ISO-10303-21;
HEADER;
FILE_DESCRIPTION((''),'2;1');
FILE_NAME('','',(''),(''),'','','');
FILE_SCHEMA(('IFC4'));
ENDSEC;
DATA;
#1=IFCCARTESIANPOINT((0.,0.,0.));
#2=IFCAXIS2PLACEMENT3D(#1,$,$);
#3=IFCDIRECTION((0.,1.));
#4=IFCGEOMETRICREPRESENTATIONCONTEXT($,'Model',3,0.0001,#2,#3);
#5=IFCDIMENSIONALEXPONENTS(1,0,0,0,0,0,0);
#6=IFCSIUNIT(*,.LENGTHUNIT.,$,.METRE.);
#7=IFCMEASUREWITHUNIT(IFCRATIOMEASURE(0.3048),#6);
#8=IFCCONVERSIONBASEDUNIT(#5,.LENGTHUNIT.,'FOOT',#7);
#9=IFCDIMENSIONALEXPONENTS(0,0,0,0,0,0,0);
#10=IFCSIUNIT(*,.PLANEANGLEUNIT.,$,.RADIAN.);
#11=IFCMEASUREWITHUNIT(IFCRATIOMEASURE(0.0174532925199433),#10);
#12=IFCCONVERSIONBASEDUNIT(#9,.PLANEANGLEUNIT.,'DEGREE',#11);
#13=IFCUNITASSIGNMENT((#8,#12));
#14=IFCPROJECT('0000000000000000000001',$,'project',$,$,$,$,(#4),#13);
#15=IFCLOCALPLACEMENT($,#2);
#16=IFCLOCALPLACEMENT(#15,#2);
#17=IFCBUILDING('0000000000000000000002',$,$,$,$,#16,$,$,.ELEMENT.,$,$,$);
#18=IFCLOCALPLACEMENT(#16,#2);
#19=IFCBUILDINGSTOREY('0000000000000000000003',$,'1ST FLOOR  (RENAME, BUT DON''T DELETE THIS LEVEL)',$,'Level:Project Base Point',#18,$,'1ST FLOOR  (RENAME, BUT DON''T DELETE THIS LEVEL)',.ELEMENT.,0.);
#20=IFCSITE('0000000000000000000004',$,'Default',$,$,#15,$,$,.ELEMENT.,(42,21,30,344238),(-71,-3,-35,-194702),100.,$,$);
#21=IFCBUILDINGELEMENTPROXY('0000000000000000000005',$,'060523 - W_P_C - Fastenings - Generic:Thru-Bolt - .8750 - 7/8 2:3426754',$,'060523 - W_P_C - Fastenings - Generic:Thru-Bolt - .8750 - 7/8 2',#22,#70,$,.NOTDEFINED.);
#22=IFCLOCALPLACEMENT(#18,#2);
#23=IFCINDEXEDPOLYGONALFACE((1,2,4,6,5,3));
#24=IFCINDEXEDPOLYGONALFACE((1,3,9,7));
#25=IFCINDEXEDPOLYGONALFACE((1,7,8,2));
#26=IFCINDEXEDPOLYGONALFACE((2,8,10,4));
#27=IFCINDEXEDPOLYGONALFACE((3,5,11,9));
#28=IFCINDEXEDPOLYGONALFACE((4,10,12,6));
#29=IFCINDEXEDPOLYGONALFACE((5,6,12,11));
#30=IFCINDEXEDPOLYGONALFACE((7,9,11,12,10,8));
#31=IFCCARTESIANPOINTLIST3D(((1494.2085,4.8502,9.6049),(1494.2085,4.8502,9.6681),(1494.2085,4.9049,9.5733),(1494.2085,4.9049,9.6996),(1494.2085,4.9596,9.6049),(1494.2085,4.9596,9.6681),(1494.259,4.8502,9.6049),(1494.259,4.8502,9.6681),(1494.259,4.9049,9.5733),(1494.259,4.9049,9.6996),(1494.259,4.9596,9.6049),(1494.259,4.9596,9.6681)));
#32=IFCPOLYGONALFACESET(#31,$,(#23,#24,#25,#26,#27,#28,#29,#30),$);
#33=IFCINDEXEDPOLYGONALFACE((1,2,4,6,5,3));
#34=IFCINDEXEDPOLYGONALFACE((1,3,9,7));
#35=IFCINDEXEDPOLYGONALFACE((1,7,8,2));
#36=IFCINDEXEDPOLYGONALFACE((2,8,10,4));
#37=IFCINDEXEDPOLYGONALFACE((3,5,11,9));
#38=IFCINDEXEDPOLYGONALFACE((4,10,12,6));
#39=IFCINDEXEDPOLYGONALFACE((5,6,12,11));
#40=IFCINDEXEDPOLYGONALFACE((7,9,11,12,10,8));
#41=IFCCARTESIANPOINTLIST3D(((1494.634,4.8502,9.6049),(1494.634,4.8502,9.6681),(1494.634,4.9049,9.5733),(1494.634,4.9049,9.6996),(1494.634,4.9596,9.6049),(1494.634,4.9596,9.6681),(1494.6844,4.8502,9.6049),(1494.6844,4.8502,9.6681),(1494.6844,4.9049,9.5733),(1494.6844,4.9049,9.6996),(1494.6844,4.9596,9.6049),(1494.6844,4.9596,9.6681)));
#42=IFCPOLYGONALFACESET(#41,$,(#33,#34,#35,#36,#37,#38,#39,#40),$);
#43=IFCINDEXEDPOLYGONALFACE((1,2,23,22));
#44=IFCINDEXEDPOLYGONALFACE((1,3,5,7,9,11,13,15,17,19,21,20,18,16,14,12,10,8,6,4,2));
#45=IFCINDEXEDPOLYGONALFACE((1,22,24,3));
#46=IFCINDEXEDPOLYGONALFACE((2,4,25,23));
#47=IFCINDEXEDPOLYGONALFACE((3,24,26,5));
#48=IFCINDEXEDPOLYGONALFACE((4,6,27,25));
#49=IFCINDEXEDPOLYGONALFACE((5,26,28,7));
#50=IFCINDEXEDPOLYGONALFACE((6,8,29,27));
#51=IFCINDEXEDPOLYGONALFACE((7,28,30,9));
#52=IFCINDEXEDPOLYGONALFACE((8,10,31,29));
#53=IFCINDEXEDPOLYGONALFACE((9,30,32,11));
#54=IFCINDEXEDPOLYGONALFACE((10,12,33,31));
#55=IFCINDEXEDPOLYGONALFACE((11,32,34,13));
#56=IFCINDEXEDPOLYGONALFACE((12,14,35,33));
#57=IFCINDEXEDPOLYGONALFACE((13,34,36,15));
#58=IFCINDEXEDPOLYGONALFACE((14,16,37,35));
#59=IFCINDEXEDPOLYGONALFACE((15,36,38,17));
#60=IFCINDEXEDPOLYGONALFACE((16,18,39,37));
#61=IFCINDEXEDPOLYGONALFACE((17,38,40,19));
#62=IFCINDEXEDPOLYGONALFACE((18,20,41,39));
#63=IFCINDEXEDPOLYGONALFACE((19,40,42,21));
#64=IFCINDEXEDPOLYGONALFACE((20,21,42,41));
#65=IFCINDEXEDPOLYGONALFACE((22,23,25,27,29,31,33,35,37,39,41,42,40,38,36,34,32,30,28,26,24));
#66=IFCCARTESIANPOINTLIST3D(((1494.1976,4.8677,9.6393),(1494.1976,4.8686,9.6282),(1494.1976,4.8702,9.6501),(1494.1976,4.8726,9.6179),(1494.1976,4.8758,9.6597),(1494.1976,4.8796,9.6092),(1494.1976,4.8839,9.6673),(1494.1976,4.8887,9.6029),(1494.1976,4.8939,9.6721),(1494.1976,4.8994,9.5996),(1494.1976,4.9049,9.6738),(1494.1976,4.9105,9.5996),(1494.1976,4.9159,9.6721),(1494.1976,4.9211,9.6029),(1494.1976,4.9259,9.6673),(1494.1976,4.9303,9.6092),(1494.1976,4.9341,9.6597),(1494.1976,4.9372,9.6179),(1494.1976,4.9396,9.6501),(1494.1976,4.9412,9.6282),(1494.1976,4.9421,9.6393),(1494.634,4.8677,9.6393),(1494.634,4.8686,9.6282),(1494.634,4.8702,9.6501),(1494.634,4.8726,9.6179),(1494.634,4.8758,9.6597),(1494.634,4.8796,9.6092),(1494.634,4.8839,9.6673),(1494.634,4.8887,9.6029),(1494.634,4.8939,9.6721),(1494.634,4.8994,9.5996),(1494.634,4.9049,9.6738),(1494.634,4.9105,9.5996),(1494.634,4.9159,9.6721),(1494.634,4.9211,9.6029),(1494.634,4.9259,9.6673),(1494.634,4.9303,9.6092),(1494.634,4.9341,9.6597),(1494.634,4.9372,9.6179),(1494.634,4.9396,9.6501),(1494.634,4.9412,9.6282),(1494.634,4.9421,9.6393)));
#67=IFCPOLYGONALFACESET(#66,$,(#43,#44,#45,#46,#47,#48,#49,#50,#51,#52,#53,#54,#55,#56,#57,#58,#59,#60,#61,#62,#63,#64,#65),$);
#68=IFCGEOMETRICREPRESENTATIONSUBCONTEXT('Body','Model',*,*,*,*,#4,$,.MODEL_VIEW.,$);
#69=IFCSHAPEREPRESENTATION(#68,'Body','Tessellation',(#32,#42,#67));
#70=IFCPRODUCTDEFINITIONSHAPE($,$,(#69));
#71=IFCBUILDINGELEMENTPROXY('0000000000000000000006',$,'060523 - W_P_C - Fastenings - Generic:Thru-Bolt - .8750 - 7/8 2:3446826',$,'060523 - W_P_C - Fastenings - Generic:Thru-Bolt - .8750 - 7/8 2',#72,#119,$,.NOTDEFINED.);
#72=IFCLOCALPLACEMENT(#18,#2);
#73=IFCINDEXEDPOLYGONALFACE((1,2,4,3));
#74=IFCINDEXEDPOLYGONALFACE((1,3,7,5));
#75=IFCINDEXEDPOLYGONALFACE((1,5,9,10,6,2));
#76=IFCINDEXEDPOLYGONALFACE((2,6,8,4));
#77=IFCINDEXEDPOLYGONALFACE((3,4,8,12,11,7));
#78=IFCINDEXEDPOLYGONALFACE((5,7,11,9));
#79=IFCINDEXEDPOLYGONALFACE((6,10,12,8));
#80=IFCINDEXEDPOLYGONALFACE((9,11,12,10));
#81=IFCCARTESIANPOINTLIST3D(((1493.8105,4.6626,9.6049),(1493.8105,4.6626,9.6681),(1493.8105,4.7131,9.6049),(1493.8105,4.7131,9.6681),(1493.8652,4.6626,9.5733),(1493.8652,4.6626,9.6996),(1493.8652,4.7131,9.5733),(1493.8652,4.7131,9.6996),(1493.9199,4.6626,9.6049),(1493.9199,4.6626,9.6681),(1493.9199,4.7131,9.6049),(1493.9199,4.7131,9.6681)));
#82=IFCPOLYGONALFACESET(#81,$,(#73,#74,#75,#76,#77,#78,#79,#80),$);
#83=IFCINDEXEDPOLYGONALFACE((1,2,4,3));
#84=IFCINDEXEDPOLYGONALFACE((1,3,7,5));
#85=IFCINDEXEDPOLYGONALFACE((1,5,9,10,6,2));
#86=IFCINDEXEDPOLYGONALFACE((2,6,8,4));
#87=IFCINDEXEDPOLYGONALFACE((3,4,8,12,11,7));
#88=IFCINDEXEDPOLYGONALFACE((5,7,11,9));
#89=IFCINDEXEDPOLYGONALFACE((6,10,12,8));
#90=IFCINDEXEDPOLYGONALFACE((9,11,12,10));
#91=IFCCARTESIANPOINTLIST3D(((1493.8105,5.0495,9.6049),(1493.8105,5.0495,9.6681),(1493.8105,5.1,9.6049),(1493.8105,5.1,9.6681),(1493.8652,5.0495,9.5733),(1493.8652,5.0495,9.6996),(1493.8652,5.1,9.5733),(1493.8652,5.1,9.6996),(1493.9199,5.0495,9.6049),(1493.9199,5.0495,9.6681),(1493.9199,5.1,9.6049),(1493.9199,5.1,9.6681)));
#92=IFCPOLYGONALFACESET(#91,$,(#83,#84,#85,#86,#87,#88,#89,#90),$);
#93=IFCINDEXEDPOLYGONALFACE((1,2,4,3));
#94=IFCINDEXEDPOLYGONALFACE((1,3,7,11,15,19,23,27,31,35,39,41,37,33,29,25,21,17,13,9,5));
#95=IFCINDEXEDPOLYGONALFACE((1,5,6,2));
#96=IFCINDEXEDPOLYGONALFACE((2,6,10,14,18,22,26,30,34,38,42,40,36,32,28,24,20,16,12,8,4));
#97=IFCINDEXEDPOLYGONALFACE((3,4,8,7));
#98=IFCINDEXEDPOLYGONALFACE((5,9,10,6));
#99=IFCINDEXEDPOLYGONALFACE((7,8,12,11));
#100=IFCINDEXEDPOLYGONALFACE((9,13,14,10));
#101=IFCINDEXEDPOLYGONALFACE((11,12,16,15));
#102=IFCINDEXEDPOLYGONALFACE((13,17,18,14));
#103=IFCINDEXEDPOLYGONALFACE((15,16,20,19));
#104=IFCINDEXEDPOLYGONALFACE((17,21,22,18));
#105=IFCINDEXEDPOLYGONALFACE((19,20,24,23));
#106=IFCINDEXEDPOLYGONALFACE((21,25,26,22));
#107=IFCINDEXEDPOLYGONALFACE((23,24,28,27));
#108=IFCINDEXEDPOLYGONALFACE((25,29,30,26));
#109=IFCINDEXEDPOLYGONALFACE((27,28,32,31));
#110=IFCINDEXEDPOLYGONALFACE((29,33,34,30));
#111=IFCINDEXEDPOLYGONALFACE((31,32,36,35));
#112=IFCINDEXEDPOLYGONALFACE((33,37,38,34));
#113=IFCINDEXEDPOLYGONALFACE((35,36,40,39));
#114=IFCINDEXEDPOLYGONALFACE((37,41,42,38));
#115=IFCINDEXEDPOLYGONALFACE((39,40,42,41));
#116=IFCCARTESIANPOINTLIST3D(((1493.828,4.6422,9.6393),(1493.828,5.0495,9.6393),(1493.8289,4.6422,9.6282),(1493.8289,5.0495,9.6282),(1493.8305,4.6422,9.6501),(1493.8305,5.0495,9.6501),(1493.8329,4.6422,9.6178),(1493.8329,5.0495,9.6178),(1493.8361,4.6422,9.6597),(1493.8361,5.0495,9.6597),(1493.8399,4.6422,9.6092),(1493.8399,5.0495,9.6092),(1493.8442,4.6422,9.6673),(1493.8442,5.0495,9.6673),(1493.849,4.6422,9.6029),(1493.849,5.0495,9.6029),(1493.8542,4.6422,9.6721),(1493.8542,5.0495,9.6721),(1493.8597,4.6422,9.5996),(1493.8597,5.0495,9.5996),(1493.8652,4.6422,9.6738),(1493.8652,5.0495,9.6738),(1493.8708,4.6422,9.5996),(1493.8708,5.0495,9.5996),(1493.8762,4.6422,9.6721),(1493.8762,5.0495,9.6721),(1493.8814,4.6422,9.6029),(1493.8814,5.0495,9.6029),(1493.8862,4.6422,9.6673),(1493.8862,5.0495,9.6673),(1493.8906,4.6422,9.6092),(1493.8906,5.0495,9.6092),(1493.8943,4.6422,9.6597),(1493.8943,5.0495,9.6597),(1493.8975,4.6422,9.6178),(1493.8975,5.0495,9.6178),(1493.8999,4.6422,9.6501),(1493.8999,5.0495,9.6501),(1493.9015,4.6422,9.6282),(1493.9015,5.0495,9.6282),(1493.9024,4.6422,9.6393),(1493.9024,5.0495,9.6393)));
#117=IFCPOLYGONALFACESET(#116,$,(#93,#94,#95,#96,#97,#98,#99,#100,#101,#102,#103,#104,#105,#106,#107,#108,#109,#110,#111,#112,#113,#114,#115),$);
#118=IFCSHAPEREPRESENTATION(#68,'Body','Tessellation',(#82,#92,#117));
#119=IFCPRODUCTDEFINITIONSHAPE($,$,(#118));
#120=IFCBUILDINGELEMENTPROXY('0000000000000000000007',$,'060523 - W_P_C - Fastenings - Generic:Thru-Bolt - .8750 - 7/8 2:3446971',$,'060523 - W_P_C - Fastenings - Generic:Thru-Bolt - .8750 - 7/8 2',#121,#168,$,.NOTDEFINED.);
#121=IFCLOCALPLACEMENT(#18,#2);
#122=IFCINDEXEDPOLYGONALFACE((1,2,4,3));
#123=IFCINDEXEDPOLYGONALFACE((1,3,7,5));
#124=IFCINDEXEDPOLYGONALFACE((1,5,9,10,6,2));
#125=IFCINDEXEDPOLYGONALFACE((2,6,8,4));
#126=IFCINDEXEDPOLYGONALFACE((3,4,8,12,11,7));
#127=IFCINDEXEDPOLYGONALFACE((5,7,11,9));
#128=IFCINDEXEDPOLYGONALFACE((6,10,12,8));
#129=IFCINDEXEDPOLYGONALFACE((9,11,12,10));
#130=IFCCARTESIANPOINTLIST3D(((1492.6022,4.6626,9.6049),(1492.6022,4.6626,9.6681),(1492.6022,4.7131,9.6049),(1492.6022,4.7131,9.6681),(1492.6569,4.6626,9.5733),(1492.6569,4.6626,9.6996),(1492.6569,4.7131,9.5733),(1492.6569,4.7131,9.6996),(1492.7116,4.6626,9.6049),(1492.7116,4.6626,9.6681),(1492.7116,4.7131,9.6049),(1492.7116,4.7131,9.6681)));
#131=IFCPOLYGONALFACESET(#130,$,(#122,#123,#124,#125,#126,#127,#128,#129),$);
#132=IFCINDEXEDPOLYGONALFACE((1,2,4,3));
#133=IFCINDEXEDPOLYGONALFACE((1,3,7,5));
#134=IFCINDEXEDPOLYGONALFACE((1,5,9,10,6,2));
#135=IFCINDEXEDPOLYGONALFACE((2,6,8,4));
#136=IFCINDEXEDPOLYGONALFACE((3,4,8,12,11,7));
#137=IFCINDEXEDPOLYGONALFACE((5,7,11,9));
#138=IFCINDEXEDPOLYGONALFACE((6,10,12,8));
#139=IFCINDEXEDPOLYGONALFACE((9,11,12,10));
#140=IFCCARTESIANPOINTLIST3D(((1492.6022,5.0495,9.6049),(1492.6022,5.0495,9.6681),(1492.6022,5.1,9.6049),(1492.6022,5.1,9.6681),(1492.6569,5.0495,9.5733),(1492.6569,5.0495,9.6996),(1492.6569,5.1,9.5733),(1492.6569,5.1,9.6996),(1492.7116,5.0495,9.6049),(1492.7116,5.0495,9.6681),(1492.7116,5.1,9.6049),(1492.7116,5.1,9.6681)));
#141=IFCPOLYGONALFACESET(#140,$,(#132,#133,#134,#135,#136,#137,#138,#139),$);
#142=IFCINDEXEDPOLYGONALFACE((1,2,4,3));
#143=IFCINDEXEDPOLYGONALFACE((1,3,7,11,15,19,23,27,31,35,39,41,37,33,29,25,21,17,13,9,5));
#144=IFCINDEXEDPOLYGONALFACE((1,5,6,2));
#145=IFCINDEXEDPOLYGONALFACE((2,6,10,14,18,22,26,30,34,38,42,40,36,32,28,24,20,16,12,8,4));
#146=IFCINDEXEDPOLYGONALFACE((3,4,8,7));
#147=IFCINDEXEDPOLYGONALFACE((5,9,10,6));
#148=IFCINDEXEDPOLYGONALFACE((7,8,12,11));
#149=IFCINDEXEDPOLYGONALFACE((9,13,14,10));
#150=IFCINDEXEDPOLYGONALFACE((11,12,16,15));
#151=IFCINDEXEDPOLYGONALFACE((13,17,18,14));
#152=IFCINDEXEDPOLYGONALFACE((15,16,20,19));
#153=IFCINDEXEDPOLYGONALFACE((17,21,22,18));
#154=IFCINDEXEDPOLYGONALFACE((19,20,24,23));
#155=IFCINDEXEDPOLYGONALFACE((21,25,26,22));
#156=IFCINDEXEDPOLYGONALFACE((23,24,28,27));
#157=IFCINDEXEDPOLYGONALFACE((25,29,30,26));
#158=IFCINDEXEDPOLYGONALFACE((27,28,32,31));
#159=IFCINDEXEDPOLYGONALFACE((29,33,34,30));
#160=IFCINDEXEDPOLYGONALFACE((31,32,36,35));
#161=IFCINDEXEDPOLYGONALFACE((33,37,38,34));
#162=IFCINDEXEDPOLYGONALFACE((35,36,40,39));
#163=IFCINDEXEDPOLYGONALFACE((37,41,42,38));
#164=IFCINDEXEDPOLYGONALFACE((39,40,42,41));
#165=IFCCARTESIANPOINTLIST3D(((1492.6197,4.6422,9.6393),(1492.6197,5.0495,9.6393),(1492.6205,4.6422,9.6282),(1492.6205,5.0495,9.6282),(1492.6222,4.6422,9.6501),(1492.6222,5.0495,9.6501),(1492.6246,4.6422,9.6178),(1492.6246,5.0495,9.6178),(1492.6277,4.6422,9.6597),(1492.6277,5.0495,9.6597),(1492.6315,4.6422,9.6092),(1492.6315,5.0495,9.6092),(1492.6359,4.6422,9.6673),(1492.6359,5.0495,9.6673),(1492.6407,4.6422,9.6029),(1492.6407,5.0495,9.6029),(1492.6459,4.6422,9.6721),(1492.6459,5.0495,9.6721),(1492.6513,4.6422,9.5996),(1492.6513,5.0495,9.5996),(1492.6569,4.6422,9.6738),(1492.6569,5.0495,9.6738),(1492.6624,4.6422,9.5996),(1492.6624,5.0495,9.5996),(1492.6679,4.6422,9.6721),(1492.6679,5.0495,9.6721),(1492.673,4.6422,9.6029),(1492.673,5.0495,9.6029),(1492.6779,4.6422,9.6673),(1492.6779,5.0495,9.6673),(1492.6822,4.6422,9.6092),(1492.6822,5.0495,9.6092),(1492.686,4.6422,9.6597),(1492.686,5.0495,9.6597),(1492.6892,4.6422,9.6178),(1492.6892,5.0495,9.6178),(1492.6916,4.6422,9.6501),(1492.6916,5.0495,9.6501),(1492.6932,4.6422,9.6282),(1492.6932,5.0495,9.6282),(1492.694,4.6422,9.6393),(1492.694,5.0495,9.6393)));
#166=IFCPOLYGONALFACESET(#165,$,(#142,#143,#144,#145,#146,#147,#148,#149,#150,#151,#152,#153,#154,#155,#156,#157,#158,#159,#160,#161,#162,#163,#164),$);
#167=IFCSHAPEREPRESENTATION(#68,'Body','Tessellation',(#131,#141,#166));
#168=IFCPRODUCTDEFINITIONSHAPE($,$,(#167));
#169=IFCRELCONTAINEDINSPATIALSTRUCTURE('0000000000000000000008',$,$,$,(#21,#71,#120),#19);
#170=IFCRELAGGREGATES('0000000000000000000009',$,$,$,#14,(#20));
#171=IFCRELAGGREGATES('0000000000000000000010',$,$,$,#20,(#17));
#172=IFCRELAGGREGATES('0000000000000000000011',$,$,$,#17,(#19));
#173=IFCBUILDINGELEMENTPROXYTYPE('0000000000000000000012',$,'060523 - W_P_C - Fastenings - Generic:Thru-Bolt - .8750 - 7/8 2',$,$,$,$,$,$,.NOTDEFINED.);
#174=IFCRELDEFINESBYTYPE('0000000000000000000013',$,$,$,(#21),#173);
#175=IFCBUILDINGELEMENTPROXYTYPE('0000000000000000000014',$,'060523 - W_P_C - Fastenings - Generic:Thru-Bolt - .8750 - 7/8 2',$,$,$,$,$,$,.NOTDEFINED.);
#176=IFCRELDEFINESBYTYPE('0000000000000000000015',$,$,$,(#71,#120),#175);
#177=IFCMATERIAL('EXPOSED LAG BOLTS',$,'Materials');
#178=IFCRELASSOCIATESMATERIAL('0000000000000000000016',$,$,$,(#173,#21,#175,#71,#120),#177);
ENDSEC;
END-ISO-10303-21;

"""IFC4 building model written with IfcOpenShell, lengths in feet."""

from ifc_helpers import new_model, entity, si_unit, converted_unit, direction, frame, frame_2d, origin, place, context, subcontext, project, spatial, polyline, circle, outline, extrude, source, transform, mapped, material, type_object, type_shapes, element, save


model = new_model("IFC4")

# Units and contexts
model_context = context("Model", 3, precision=0.0001, world=origin(), true_north=direction((0.0, 1.0)))
body_context = subcontext(model_context, "Body", "Model", "MODEL_VIEW")
ifc_project = project(units=[converted_unit("LENGTHUNIT", "FOOT", entity("IfcRatioMeasure", 0.3048), si_unit("LENGTHUNIT", "METRE"), dimensions=[1, 0, 0, 0, 0, 0, 0]), converted_unit("PLANEANGLEUNIT", "DEGREE", entity("IfcRatioMeasure", 0.0174532925199433), si_unit("PLANEANGLEUNIT", "RADIAN"), dimensions=[0, 0, 0, 0, 0, 0, 0])], contexts=[model_context])

# Site, building, storey
site_placement = place(None, origin())
site = spatial("IfcSite", under=ifc_project, at=site_placement, Name="Default", CompositionType="ELEMENT", RefLatitude=(42, 21, 30, 344238), RefLongitude=(-71, -3, -35, -194702), RefElevation=100.0)
building_placement = place(site_placement, origin())
building = spatial("IfcBuilding", under=site, at=building_placement, CompositionType="ELEMENT")
storey_placement = place(building_placement, origin())
storey = spatial("IfcBuildingStorey", under=building, at=storey_placement, Name="1ST FLOOR  (RENAME, BUT DON'T DELETE THIS LEVEL)", ObjectType="Level:Project Base Point", LongName="1ST FLOOR  (RENAME, BUT DON'T DELETE THIS LEVEL)", CompositionType="ELEMENT", Elevation=0.0)

# Building element proxies
ifc_material_1 = material(Name="EXPOSED LAG BOLTS", Category="Materials")
building_element_proxy_type_1 = type_object("IfcBuildingElementProxyType", Name="060523 - W_P_C - Fastenings - Generic:Thru-Bolt - .8750 - 7/8 2", PredefinedType="NOTDEFINED", material=ifc_material_1)
shared_shape_1 = source(origin(), body_context, "Body", "SweptSolid", [
    extrude(outline(polyline([(-0.0316, -0.0547), (0.0316, -0.0547), (0.0631, 0.0), (0.0316, 0.0547), (-0.0316, 0.0547), (-0.0631, 0.0), (-0.0316, -0.0547)])), frame((0.0, 0.0, -0.4255), z_axis=(0.0, 0.0, 1.0), x_axis=(0.866025, -0.5, 0.0)), (0.0, 0.0, 1.0), 0.0505),
    extrude(outline(polyline([(-0.0316, -0.0547), (0.0316, -0.0547), (0.0631, 0.0), (0.0316, 0.0547), (-0.0316, 0.0547), (-0.0631, 0.0), (-0.0316, -0.0547)])), frame((0.0, 0.0, 0.0), z_axis=(0.0, 0.0, 1.0), x_axis=(0.0, -1.0, 0.0)), (0.0, 0.0, 1.0), 0.0505),
    extrude(circle(Radius=0.0373, at=frame_2d((0.0, 0.0), x_axis=(1.0, 0.0))), frame((0.0, 0.0, -0.4364), z_axis=(0.0, 0.0, 1.0), x_axis=(0.0, 1.0, 0.0)), (0.0, 0.0, 1.0), 0.4364),
])
type_shapes(building_element_proxy_type_1, [shared_shape_1])
proxy_1_placement = place(storey_placement, frame((1494.634, 4.9049, 9.6365), z_axis=(1.0, 0.0, 0.0), x_axis=(0.0, 1.0, 0.0)))
element("IfcBuildingElementProxy", 1, at=proxy_1_placement, inside=storey, type_object=building_element_proxy_type_1, material=ifc_material_1, Name="060523 - W_P_C - Fastenings - Generic:Thru-Bolt - .8750 - 7/8 2:3426754", ObjectType="060523 - W_P_C - Fastenings - Generic:Thru-Bolt - .8750 - 7/8 2", PredefinedType="NOTDEFINED", context=body_context, shape_type="MappedRepresentation", body=[
    mapped(shared_shape_1, transform((0.0, 0.0, 0.0), scale=1.0)),
])
building_element_proxy_type_2 = type_object("IfcBuildingElementProxyType", Name="060523 - W_P_C - Fastenings - Generic:Thru-Bolt - .8750 - 7/8 2", PredefinedType="NOTDEFINED", material=ifc_material_1)
shared_shape_2 = source(origin(), body_context, "Body", "SweptSolid", [
    extrude(outline(polyline([(-0.0316, -0.0547), (0.0316, -0.0547), (0.0631, 0.0), (0.0316, 0.0547), (-0.0316, 0.0547), (-0.0631, 0.0), (-0.0316, -0.0547)])), frame((0.0, 0.0, -0.3869), z_axis=(0.0, 0.0, 1.0), x_axis=(0.866025, -0.5, 0.0)), (0.0, 0.0, 1.0), 0.0505),
    extrude(outline(polyline([(-0.0316, -0.0547), (0.0316, -0.0547), (0.0631, 0.0), (0.0316, 0.0547), (-0.0316, 0.0547), (-0.0631, 0.0), (-0.0316, -0.0547)])), frame((0.0, 0.0, 0.0), z_axis=(0.0, 0.0, 1.0), x_axis=(0.0, -1.0, 0.0)), (0.0, 0.0, 1.0), 0.0505),
    extrude(circle(Radius=0.0373, at=frame_2d((0.0, 0.0), x_axis=(1.0, 0.0))), frame((0.0, 0.0, -0.4073), z_axis=(0.0, 0.0, 1.0), x_axis=(0.0, 1.0, 0.0)), (0.0, 0.0, 1.0), 0.4073),
])
type_shapes(building_element_proxy_type_2, [shared_shape_2])
for number, where, z_axis, x_axis, name in (
    (2, (1493.8652, 5.0495, 9.6365), (0.0, 1.0, 0.0), (-1.0, 0.0, 0.0), "060523 - W_P_C - Fastenings - Generic:Thru-Bolt - .8750 - 7/8 2:3446826"),
    (3, (1492.6569, 5.0495, 9.6365), (0.0, 1.0, 0.0), (-1.0, 0.0, 0.0), "060523 - W_P_C - Fastenings - Generic:Thru-Bolt - .8750 - 7/8 2:3446971"),
):
    element("IfcBuildingElementProxy", number, at=place(storey_placement, frame(where, z_axis=z_axis, x_axis=x_axis)), inside=storey, type_object=building_element_proxy_type_2, material=ifc_material_1, Name=name, ObjectType="060523 - W_P_C - Fastenings - Generic:Thru-Bolt - .8750 - 7/8 2", PredefinedType="NOTDEFINED", context=body_context, shape_type="MappedRepresentation", body=[
        mapped(shared_shape_2, transform((0.0, 0.0, 0.0), scale=1.0)),
    ])

save(model, "model.ifc")
